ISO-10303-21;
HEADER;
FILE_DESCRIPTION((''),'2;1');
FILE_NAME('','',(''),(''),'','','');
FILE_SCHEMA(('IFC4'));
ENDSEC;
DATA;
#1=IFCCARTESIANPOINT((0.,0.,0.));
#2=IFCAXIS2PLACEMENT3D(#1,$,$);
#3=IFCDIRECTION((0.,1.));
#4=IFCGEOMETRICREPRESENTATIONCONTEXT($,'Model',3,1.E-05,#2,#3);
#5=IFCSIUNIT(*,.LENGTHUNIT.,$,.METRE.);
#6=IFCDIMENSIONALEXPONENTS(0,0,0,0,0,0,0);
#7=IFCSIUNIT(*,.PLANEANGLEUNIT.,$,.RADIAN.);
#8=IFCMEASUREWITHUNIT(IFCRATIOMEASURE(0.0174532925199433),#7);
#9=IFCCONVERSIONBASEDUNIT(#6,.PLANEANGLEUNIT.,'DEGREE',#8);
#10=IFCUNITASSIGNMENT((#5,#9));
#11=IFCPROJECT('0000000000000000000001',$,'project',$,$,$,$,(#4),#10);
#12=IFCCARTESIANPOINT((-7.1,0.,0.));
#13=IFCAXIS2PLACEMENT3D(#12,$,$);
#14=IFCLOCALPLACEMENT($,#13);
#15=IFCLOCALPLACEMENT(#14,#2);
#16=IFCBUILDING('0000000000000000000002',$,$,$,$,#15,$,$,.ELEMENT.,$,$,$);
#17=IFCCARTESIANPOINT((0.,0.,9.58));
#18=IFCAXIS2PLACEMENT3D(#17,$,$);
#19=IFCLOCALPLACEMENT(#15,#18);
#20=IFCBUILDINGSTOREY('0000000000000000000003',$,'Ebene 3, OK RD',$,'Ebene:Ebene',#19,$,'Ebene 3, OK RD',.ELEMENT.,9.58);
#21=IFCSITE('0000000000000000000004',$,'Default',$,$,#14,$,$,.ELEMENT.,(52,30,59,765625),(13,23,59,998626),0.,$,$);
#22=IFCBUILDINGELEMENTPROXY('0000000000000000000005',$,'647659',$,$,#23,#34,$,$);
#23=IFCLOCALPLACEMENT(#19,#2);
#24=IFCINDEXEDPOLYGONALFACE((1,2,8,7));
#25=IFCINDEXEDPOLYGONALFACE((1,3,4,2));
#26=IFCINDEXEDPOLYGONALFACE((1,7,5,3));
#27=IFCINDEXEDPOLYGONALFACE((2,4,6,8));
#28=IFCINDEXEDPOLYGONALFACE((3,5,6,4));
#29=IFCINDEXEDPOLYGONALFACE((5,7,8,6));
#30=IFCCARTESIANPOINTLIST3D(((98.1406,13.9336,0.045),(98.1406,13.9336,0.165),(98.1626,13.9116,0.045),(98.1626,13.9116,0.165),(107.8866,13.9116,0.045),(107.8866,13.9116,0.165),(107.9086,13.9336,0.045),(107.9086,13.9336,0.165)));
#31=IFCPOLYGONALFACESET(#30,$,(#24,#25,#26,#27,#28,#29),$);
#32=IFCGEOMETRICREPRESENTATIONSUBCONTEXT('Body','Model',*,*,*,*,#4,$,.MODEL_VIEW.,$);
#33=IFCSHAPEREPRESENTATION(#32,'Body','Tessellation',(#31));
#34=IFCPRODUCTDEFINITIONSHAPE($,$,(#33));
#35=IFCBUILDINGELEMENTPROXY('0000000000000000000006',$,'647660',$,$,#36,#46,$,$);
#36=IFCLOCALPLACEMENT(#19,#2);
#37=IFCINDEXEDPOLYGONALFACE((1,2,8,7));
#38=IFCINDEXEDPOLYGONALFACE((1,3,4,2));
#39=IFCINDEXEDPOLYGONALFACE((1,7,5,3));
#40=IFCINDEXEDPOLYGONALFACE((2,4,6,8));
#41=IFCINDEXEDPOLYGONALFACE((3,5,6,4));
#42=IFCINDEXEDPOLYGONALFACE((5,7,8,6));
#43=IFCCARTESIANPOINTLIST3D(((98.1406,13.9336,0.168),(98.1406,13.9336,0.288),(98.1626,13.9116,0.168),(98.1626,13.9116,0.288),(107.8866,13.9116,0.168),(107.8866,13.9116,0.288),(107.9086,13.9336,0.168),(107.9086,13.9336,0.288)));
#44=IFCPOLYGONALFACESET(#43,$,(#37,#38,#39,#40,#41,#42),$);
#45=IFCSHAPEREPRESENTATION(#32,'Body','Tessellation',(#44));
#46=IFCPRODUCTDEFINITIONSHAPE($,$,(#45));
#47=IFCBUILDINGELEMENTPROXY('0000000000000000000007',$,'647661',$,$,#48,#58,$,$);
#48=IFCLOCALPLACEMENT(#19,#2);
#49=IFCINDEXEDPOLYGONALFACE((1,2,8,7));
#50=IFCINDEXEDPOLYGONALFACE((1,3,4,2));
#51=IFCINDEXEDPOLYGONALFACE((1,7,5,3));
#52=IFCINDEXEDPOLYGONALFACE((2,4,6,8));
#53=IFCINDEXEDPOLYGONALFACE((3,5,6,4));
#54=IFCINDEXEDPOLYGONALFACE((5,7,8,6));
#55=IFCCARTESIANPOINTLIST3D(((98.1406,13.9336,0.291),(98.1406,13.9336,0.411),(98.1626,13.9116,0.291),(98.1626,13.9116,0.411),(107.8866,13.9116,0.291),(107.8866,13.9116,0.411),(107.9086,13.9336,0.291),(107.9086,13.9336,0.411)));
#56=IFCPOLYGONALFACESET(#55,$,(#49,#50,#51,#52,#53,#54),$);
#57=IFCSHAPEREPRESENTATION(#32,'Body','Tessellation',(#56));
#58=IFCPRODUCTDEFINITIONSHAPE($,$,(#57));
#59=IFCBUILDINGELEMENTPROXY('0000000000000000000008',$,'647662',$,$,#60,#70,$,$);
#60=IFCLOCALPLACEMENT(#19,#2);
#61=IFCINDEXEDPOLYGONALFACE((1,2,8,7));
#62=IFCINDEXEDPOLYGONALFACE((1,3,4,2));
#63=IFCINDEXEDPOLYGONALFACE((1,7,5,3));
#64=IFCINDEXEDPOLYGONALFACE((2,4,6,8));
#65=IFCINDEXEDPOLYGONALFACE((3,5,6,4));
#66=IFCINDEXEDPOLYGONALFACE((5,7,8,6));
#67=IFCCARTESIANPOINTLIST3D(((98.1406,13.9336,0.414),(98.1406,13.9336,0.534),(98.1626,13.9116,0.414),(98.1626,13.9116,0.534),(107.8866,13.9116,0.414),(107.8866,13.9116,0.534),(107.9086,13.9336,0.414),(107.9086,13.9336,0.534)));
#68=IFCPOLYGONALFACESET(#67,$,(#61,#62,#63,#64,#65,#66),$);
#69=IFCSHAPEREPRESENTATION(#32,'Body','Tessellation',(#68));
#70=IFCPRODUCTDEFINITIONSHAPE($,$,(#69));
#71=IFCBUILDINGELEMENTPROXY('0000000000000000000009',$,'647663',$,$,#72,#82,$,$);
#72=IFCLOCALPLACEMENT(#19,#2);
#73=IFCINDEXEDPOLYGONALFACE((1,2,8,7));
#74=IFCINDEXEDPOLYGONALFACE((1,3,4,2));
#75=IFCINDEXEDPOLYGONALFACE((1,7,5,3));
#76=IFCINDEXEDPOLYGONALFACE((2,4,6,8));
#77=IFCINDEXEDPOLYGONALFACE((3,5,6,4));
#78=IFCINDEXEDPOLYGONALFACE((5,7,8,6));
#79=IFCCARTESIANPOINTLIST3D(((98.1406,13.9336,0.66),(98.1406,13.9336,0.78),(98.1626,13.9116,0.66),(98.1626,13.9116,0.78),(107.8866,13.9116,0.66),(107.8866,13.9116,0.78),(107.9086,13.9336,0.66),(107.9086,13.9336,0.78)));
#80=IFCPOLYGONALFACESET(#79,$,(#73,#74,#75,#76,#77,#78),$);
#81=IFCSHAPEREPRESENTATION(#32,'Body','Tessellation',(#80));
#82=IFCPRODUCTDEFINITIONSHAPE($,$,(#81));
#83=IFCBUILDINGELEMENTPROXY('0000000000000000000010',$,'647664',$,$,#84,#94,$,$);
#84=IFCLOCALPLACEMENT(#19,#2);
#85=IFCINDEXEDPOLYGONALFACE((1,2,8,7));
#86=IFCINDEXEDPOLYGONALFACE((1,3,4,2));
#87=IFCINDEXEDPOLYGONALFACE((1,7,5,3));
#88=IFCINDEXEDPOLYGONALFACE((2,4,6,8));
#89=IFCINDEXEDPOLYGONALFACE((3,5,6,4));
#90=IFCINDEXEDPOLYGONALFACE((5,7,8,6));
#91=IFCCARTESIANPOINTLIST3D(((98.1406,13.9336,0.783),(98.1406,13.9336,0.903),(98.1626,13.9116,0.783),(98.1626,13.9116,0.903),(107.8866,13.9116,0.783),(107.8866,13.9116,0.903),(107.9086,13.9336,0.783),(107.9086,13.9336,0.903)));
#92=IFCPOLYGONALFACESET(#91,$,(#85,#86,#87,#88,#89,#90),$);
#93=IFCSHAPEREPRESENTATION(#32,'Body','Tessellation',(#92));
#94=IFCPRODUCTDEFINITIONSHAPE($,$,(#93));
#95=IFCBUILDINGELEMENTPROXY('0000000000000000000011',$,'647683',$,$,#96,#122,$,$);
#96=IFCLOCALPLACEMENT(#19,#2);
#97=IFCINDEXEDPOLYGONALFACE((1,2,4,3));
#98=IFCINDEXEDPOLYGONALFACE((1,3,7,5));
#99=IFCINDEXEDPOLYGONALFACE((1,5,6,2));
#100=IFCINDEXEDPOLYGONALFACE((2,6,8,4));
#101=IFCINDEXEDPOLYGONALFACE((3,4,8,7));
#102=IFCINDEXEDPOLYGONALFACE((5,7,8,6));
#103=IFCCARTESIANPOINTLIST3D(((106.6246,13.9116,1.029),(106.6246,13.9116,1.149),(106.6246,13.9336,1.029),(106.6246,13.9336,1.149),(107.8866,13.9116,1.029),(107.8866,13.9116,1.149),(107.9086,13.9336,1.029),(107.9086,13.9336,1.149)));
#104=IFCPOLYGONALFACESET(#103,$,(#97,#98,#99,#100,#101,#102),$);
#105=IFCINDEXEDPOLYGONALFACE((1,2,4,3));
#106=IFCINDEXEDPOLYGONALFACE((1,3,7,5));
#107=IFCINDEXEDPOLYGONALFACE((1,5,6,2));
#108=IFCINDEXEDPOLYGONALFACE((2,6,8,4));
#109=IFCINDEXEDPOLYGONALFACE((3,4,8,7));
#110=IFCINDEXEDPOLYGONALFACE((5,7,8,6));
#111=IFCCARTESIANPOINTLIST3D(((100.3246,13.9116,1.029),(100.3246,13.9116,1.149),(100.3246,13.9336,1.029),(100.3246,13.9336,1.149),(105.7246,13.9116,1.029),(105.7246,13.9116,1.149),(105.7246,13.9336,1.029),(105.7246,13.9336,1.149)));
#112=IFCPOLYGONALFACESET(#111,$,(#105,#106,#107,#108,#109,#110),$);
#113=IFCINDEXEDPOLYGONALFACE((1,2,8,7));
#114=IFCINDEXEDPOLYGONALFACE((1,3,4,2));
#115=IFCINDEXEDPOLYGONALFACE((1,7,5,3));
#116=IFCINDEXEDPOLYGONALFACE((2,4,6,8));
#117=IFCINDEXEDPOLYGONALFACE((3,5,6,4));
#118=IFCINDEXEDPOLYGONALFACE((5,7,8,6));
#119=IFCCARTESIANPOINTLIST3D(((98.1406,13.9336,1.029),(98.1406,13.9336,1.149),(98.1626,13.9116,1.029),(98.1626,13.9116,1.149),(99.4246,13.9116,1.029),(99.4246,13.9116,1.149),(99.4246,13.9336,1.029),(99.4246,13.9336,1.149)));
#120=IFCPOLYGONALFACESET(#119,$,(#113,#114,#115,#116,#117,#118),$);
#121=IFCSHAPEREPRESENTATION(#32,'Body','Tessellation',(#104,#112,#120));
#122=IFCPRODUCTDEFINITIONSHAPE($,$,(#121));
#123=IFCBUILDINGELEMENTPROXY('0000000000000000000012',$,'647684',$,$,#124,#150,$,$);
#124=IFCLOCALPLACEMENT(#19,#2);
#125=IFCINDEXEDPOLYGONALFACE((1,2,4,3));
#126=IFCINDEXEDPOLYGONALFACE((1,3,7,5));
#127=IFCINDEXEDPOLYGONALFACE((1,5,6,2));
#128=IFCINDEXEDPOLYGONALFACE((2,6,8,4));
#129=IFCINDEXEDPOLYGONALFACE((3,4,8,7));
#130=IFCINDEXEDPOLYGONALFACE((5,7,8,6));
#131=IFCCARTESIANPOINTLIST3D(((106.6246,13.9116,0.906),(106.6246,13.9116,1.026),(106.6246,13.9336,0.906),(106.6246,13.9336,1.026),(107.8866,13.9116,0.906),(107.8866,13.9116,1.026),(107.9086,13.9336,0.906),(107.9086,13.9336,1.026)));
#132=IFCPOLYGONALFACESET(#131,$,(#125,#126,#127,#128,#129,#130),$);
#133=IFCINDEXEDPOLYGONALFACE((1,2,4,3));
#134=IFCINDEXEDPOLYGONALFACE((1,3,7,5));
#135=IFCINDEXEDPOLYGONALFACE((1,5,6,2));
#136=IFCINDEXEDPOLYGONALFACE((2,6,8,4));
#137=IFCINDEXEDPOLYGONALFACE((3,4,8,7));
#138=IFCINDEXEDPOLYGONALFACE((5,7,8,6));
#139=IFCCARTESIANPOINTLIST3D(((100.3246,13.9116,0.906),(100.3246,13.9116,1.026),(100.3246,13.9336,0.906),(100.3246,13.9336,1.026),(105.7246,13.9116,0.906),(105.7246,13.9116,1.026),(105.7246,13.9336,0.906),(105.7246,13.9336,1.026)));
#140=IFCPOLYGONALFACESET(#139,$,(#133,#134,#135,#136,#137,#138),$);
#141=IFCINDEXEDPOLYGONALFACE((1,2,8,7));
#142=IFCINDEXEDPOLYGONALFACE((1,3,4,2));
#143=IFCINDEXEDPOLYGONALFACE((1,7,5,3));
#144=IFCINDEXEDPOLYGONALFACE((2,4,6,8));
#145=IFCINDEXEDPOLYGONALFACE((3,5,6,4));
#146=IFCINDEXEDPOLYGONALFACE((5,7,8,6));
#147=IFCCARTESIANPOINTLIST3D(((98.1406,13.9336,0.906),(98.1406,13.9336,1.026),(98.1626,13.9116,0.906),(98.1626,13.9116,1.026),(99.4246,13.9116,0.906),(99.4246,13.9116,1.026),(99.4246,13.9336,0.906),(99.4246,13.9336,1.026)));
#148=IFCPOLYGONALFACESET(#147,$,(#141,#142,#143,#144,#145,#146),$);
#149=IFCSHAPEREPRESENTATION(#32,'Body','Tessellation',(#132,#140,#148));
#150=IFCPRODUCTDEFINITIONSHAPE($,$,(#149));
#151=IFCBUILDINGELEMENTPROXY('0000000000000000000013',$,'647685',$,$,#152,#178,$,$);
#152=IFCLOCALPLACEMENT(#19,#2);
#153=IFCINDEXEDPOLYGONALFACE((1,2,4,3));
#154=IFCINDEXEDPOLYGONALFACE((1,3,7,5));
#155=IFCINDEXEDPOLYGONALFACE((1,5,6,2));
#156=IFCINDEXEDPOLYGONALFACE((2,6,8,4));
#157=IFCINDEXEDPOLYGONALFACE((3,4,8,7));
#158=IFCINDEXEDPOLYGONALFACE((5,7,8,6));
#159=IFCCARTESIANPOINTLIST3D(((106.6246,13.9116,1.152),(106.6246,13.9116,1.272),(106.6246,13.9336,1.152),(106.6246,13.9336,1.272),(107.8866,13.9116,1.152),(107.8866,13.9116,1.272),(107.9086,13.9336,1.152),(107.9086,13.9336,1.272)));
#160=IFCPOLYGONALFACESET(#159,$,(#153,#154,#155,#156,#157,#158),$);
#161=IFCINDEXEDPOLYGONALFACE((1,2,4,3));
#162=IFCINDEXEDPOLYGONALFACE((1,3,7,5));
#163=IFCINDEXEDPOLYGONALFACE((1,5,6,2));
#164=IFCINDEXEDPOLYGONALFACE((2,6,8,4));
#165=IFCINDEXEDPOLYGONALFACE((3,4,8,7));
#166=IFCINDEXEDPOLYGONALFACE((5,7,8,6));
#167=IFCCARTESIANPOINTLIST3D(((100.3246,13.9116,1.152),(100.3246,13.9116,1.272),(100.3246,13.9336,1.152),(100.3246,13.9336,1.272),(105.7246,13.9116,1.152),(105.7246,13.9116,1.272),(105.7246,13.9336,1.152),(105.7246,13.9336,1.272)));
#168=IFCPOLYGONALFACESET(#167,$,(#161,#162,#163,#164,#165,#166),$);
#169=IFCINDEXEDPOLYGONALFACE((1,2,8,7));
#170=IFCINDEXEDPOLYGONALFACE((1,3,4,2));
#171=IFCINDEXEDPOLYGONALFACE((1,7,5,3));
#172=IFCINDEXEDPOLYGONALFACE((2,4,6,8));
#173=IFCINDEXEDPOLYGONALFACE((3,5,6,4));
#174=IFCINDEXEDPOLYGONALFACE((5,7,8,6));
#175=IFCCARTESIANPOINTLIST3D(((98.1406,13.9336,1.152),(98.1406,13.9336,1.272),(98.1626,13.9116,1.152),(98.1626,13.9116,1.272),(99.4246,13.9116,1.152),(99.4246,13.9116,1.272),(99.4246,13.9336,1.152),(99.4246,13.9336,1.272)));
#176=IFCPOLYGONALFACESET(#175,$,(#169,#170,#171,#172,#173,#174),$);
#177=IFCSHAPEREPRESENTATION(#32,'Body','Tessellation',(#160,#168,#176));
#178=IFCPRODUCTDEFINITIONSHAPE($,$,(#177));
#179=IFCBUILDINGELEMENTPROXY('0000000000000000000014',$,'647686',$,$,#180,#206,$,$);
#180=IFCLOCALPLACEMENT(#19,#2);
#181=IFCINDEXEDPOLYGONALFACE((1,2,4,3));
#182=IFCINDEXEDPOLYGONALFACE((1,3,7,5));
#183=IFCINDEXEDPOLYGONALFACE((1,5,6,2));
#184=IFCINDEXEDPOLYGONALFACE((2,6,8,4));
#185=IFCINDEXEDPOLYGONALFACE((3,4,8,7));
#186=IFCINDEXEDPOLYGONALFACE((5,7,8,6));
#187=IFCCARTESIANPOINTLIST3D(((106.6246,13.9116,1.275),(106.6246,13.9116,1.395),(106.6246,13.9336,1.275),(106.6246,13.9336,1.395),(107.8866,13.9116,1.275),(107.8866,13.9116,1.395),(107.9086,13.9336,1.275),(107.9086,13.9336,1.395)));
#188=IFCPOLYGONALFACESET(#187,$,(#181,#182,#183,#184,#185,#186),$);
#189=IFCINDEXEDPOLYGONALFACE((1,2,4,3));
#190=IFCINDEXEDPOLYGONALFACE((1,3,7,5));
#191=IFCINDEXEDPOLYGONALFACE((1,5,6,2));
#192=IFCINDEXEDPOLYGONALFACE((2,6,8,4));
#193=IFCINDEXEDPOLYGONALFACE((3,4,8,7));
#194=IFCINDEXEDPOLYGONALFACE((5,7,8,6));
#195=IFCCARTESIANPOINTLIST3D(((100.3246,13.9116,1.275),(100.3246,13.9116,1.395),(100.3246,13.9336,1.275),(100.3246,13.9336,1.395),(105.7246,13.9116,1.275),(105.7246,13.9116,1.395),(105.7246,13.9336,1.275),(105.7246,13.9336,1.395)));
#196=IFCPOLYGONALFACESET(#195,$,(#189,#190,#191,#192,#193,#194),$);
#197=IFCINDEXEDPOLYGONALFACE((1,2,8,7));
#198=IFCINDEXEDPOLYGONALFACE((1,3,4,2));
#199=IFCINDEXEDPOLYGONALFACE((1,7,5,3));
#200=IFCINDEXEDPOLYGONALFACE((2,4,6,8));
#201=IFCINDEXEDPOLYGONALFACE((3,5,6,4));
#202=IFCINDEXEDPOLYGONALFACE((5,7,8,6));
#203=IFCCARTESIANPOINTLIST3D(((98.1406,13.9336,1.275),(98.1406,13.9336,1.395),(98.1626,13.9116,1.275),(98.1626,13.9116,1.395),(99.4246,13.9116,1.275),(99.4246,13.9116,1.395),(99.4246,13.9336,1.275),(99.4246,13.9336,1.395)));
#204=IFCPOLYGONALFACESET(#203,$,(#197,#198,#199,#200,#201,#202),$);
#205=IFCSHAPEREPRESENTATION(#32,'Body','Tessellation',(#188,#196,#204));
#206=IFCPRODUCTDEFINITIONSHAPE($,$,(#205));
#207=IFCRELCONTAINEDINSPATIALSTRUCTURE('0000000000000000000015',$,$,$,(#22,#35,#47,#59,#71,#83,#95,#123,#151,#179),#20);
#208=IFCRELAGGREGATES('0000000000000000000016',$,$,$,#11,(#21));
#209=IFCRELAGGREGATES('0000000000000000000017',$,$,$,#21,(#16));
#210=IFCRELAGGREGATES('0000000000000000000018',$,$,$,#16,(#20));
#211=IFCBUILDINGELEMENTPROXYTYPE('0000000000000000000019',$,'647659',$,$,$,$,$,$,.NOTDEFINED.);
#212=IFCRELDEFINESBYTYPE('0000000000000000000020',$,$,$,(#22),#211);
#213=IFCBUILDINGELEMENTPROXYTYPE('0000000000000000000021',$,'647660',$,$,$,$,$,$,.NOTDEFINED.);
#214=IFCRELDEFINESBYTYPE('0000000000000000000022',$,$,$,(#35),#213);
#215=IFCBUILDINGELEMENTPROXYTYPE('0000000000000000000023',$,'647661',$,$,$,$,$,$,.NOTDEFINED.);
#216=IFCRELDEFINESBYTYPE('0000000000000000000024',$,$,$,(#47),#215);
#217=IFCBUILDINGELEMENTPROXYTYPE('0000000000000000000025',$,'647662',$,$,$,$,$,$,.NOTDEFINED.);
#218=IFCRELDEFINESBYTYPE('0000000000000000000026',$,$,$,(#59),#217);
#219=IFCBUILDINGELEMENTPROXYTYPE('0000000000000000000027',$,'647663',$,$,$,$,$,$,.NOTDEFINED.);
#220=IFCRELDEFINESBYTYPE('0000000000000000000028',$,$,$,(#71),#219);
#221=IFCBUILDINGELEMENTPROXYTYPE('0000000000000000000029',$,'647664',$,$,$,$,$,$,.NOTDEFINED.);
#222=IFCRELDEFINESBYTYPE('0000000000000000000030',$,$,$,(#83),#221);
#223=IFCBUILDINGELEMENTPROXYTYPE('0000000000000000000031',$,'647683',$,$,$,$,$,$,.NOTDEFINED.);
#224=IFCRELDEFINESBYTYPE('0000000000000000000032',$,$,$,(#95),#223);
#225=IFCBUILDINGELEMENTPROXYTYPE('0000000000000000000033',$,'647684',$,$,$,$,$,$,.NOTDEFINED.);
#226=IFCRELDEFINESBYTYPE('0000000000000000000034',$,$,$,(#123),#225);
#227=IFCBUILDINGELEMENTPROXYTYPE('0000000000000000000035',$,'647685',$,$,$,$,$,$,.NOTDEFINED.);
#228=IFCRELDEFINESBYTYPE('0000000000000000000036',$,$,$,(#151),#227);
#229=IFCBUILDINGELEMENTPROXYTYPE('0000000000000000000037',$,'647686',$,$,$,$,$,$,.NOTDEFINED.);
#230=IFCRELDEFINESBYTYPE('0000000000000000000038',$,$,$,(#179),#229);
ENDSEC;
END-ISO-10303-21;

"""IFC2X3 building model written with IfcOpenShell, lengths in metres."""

from ifc_helpers import new_model, entity, si_unit, converted_unit, direction, frame, frame_2d, origin, place, context, subcontext, project, spatial, polyline, rectangle, outline, extrude, type_object, element, save


model = new_model("IFC2X3")

# Units and contexts
model_context = context("Model", 3, precision=1e-05, world=origin(), true_north=direction((0.0, 1.0)))
body_context = subcontext(model_context, "Body", "Model", "MODEL_VIEW")
ifc_project = project(units=[si_unit("LENGTHUNIT", "METRE"), converted_unit("PLANEANGLEUNIT", "DEGREE", entity("IfcRatioMeasure", 0.0174532925199433), si_unit("PLANEANGLEUNIT", "RADIAN"), dimensions=[0, 0, 0, 0, 0, 0, 0])], contexts=[model_context])

# Site, building, storey
site_placement = place(None, frame((-7.1, 0.0, 0.0)))
site = spatial("IfcSite", under=ifc_project, at=site_placement, Name="Default", CompositionType="ELEMENT", RefLatitude=(52, 30, 59, 765625), RefLongitude=(13, 23, 59, 998626), RefElevation=0.0)
building_placement = place(site_placement, origin())
building = spatial("IfcBuilding", under=site, at=building_placement, CompositionType="ELEMENT")
storey_placement = place(building_placement, frame((0.0, 0.0, 9.58)))
storey = spatial("IfcBuildingStorey", under=building, at=storey_placement, Name="Ebene 3, OK RD", ObjectType="Ebene:Ebene", LongName="Ebene 3, OK RD", CompositionType="ELEMENT", Elevation=9.58)

# Building element proxies
building_element_proxy_type_1 = type_object("IfcBuildingElementProxyType", Name="647659", PredefinedType="NOTDEFINED")
proxy_1_placement = place(storey_placement, origin())
element("IfcBuildingElementProxy", 1, at=proxy_1_placement, inside=storey, type_object=building_element_proxy_type_1, Name="647659", context=body_context, shape_type="SweptSolid", body=[
    extrude(outline(polyline([(-4.862, -0.011), (4.862, -0.011), (4.884, 0.011), (-4.884, 0.011), (-4.862, -0.011)])), frame((103.0246, 13.9226, 0.045)), (0.0, 0.0, 1.0), 0.12),
])
building_element_proxy_type_2 = type_object("IfcBuildingElementProxyType", Name="647660", PredefinedType="NOTDEFINED")
proxy_2_placement = place(storey_placement, origin())
element("IfcBuildingElementProxy", 2, at=proxy_2_placement, inside=storey, type_object=building_element_proxy_type_2, Name="647660", context=body_context, shape_type="SweptSolid", body=[
    extrude(outline(polyline([(-4.862, -0.011), (4.862, -0.011), (4.884, 0.011), (-4.884, 0.011), (-4.862, -0.011)])), frame((103.0246, 13.9226, 0.168)), (0.0, 0.0, 1.0), 0.12),
])
building_element_proxy_type_3 = type_object("IfcBuildingElementProxyType", Name="647661", PredefinedType="NOTDEFINED")
proxy_3_placement = place(storey_placement, origin())
element("IfcBuildingElementProxy", 3, at=proxy_3_placement, inside=storey, type_object=building_element_proxy_type_3, Name="647661", context=body_context, shape_type="SweptSolid", body=[
    extrude(outline(polyline([(-4.862, -0.011), (4.862, -0.011), (4.884, 0.011), (-4.884, 0.011), (-4.862, -0.011)])), frame((103.0246, 13.9226, 0.291)), (0.0, 0.0, 1.0), 0.12),
])
building_element_proxy_type_4 = type_object("IfcBuildingElementProxyType", Name="647662", PredefinedType="NOTDEFINED")
proxy_4_placement = place(storey_placement, origin())
element("IfcBuildingElementProxy", 4, at=proxy_4_placement, inside=storey, type_object=building_element_proxy_type_4, Name="647662", context=body_context, shape_type="SweptSolid", body=[
    extrude(outline(polyline([(-4.862, -0.011), (4.862, -0.011), (4.884, 0.011), (-4.884, 0.011), (-4.862, -0.011)])), frame((103.0246, 13.9226, 0.414)), (0.0, 0.0, 1.0), 0.12),
])
building_element_proxy_type_5 = type_object("IfcBuildingElementProxyType", Name="647663", PredefinedType="NOTDEFINED")
proxy_5_placement = place(storey_placement, origin())
element("IfcBuildingElementProxy", 5, at=proxy_5_placement, inside=storey, type_object=building_element_proxy_type_5, Name="647663", context=body_context, shape_type="SweptSolid", body=[
    extrude(outline(polyline([(-4.862, -0.011), (4.862, -0.011), (4.884, 0.011), (-4.884, 0.011), (-4.862, -0.011)])), frame((103.0246, 13.9226, 0.66)), (0.0, 0.0, 1.0), 0.12),
])
building_element_proxy_type_6 = type_object("IfcBuildingElementProxyType", Name="647664", PredefinedType="NOTDEFINED")
proxy_6_placement = place(storey_placement, origin())
element("IfcBuildingElementProxy", 6, at=proxy_6_placement, inside=storey, type_object=building_element_proxy_type_6, Name="647664", context=body_context, shape_type="SweptSolid", body=[
    extrude(outline(polyline([(-4.862, -0.011), (4.862, -0.011), (4.884, 0.011), (-4.884, 0.011), (-4.862, -0.011)])), frame((103.0246, 13.9226, 0.783)), (0.0, 0.0, 1.0), 0.12),
])
building_element_proxy_type_7 = type_object("IfcBuildingElementProxyType", Name="647683", PredefinedType="NOTDEFINED")
proxy_7_placement = place(storey_placement, origin())
element("IfcBuildingElementProxy", 7, at=proxy_7_placement, inside=storey, type_object=building_element_proxy_type_7, Name="647683", context=body_context, shape_type="SweptSolid", body=[
    extrude(outline(polyline([(-0.6365, -0.011), (0.6255, -0.011), (0.6475, 0.011), (-0.6365, 0.011), (-0.6365, -0.011)])), frame((107.2611, 13.9226, 1.029)), (0.0, 0.0, 1.0), 0.12),
    extrude(rectangle(XDim=5.4, YDim=0.022, at=frame_2d((0.0, 0.0), x_axis=(1.0, 0.0))), frame((103.0246, 13.9226, 1.029)), (0.0, 0.0, 1.0), 0.12),
    extrude(outline(polyline([(-0.6255, -0.011), (0.6365, -0.011), (0.6365, 0.011), (-0.6475, 0.011), (-0.6255, -0.011)])), frame((98.7881, 13.9226, 1.029)), (0.0, 0.0, 1.0), 0.12),
])
building_element_proxy_type_8 = type_object("IfcBuildingElementProxyType", Name="647684", PredefinedType="NOTDEFINED")
proxy_8_placement = place(storey_placement, origin())
element("IfcBuildingElementProxy", 8, at=proxy_8_placement, inside=storey, type_object=building_element_proxy_type_8, Name="647684", context=body_context, shape_type="SweptSolid", body=[
    extrude(outline(polyline([(-0.6365, -0.011), (0.6255, -0.011), (0.6475, 0.011), (-0.6365, 0.011), (-0.6365, -0.011)])), frame((107.2611, 13.9226, 0.906)), (0.0, 0.0, 1.0), 0.12),
    extrude(rectangle(XDim=5.4, YDim=0.022, at=frame_2d((0.0, 0.0), x_axis=(1.0, 0.0))), frame((103.0246, 13.9226, 0.906)), (0.0, 0.0, 1.0), 0.12),
    extrude(outline(polyline([(-0.6255, -0.011), (0.6365, -0.011), (0.6365, 0.011), (-0.6475, 0.011), (-0.6255, -0.011)])), frame((98.7881, 13.9226, 0.906)), (0.0, 0.0, 1.0), 0.12),
])
building_element_proxy_type_9 = type_object("IfcBuildingElementProxyType", Name="647685", PredefinedType="NOTDEFINED")
proxy_9_placement = place(storey_placement, origin())
element("IfcBuildingElementProxy", 9, at=proxy_9_placement, inside=storey, type_object=building_element_proxy_type_9, Name="647685", context=body_context, shape_type="SweptSolid", body=[
    extrude(outline(polyline([(-0.6365, -0.011), (0.6255, -0.011), (0.6475, 0.011), (-0.6365, 0.011), (-0.6365, -0.011)])), frame((107.2611, 13.9226, 1.152)), (0.0, 0.0, 1.0), 0.12),
    extrude(rectangle(XDim=5.4, YDim=0.022, at=frame_2d((0.0, 0.0), x_axis=(1.0, 0.0))), frame((103.0246, 13.9226, 1.152)), (0.0, 0.0, 1.0), 0.12),
    extrude(outline(polyline([(-0.6255, -0.011), (0.6365, -0.011), (0.6365, 0.011), (-0.6475, 0.011), (-0.6255, -0.011)])), frame((98.7881, 13.9226, 1.152)), (0.0, 0.0, 1.0), 0.12),
])
building_element_proxy_type_10 = type_object("IfcBuildingElementProxyType", Name="647686", PredefinedType="NOTDEFINED")
proxy_10_placement = place(storey_placement, origin())
element("IfcBuildingElementProxy", 10, at=proxy_10_placement, inside=storey, type_object=building_element_proxy_type_10, Name="647686", context=body_context, shape_type="SweptSolid", body=[
    extrude(outline(polyline([(-0.6365, -0.011), (0.6255, -0.011), (0.6475, 0.011), (-0.6365, 0.011), (-0.6365, -0.011)])), frame((107.2611, 13.9226, 1.275)), (0.0, 0.0, 1.0), 0.12),
    extrude(rectangle(XDim=5.4, YDim=0.022, at=frame_2d((0.0, 0.0), x_axis=(1.0, 0.0))), frame((103.0246, 13.9226, 1.275)), (0.0, 0.0, 1.0), 0.12),
    extrude(outline(polyline([(-0.6255, -0.011), (0.6365, -0.011), (0.6365, 0.011), (-0.6475, 0.011), (-0.6255, -0.011)])), frame((98.7881, 13.9226, 1.275)), (0.0, 0.0, 1.0), 0.12),
])

save(model, "model.ifc")
